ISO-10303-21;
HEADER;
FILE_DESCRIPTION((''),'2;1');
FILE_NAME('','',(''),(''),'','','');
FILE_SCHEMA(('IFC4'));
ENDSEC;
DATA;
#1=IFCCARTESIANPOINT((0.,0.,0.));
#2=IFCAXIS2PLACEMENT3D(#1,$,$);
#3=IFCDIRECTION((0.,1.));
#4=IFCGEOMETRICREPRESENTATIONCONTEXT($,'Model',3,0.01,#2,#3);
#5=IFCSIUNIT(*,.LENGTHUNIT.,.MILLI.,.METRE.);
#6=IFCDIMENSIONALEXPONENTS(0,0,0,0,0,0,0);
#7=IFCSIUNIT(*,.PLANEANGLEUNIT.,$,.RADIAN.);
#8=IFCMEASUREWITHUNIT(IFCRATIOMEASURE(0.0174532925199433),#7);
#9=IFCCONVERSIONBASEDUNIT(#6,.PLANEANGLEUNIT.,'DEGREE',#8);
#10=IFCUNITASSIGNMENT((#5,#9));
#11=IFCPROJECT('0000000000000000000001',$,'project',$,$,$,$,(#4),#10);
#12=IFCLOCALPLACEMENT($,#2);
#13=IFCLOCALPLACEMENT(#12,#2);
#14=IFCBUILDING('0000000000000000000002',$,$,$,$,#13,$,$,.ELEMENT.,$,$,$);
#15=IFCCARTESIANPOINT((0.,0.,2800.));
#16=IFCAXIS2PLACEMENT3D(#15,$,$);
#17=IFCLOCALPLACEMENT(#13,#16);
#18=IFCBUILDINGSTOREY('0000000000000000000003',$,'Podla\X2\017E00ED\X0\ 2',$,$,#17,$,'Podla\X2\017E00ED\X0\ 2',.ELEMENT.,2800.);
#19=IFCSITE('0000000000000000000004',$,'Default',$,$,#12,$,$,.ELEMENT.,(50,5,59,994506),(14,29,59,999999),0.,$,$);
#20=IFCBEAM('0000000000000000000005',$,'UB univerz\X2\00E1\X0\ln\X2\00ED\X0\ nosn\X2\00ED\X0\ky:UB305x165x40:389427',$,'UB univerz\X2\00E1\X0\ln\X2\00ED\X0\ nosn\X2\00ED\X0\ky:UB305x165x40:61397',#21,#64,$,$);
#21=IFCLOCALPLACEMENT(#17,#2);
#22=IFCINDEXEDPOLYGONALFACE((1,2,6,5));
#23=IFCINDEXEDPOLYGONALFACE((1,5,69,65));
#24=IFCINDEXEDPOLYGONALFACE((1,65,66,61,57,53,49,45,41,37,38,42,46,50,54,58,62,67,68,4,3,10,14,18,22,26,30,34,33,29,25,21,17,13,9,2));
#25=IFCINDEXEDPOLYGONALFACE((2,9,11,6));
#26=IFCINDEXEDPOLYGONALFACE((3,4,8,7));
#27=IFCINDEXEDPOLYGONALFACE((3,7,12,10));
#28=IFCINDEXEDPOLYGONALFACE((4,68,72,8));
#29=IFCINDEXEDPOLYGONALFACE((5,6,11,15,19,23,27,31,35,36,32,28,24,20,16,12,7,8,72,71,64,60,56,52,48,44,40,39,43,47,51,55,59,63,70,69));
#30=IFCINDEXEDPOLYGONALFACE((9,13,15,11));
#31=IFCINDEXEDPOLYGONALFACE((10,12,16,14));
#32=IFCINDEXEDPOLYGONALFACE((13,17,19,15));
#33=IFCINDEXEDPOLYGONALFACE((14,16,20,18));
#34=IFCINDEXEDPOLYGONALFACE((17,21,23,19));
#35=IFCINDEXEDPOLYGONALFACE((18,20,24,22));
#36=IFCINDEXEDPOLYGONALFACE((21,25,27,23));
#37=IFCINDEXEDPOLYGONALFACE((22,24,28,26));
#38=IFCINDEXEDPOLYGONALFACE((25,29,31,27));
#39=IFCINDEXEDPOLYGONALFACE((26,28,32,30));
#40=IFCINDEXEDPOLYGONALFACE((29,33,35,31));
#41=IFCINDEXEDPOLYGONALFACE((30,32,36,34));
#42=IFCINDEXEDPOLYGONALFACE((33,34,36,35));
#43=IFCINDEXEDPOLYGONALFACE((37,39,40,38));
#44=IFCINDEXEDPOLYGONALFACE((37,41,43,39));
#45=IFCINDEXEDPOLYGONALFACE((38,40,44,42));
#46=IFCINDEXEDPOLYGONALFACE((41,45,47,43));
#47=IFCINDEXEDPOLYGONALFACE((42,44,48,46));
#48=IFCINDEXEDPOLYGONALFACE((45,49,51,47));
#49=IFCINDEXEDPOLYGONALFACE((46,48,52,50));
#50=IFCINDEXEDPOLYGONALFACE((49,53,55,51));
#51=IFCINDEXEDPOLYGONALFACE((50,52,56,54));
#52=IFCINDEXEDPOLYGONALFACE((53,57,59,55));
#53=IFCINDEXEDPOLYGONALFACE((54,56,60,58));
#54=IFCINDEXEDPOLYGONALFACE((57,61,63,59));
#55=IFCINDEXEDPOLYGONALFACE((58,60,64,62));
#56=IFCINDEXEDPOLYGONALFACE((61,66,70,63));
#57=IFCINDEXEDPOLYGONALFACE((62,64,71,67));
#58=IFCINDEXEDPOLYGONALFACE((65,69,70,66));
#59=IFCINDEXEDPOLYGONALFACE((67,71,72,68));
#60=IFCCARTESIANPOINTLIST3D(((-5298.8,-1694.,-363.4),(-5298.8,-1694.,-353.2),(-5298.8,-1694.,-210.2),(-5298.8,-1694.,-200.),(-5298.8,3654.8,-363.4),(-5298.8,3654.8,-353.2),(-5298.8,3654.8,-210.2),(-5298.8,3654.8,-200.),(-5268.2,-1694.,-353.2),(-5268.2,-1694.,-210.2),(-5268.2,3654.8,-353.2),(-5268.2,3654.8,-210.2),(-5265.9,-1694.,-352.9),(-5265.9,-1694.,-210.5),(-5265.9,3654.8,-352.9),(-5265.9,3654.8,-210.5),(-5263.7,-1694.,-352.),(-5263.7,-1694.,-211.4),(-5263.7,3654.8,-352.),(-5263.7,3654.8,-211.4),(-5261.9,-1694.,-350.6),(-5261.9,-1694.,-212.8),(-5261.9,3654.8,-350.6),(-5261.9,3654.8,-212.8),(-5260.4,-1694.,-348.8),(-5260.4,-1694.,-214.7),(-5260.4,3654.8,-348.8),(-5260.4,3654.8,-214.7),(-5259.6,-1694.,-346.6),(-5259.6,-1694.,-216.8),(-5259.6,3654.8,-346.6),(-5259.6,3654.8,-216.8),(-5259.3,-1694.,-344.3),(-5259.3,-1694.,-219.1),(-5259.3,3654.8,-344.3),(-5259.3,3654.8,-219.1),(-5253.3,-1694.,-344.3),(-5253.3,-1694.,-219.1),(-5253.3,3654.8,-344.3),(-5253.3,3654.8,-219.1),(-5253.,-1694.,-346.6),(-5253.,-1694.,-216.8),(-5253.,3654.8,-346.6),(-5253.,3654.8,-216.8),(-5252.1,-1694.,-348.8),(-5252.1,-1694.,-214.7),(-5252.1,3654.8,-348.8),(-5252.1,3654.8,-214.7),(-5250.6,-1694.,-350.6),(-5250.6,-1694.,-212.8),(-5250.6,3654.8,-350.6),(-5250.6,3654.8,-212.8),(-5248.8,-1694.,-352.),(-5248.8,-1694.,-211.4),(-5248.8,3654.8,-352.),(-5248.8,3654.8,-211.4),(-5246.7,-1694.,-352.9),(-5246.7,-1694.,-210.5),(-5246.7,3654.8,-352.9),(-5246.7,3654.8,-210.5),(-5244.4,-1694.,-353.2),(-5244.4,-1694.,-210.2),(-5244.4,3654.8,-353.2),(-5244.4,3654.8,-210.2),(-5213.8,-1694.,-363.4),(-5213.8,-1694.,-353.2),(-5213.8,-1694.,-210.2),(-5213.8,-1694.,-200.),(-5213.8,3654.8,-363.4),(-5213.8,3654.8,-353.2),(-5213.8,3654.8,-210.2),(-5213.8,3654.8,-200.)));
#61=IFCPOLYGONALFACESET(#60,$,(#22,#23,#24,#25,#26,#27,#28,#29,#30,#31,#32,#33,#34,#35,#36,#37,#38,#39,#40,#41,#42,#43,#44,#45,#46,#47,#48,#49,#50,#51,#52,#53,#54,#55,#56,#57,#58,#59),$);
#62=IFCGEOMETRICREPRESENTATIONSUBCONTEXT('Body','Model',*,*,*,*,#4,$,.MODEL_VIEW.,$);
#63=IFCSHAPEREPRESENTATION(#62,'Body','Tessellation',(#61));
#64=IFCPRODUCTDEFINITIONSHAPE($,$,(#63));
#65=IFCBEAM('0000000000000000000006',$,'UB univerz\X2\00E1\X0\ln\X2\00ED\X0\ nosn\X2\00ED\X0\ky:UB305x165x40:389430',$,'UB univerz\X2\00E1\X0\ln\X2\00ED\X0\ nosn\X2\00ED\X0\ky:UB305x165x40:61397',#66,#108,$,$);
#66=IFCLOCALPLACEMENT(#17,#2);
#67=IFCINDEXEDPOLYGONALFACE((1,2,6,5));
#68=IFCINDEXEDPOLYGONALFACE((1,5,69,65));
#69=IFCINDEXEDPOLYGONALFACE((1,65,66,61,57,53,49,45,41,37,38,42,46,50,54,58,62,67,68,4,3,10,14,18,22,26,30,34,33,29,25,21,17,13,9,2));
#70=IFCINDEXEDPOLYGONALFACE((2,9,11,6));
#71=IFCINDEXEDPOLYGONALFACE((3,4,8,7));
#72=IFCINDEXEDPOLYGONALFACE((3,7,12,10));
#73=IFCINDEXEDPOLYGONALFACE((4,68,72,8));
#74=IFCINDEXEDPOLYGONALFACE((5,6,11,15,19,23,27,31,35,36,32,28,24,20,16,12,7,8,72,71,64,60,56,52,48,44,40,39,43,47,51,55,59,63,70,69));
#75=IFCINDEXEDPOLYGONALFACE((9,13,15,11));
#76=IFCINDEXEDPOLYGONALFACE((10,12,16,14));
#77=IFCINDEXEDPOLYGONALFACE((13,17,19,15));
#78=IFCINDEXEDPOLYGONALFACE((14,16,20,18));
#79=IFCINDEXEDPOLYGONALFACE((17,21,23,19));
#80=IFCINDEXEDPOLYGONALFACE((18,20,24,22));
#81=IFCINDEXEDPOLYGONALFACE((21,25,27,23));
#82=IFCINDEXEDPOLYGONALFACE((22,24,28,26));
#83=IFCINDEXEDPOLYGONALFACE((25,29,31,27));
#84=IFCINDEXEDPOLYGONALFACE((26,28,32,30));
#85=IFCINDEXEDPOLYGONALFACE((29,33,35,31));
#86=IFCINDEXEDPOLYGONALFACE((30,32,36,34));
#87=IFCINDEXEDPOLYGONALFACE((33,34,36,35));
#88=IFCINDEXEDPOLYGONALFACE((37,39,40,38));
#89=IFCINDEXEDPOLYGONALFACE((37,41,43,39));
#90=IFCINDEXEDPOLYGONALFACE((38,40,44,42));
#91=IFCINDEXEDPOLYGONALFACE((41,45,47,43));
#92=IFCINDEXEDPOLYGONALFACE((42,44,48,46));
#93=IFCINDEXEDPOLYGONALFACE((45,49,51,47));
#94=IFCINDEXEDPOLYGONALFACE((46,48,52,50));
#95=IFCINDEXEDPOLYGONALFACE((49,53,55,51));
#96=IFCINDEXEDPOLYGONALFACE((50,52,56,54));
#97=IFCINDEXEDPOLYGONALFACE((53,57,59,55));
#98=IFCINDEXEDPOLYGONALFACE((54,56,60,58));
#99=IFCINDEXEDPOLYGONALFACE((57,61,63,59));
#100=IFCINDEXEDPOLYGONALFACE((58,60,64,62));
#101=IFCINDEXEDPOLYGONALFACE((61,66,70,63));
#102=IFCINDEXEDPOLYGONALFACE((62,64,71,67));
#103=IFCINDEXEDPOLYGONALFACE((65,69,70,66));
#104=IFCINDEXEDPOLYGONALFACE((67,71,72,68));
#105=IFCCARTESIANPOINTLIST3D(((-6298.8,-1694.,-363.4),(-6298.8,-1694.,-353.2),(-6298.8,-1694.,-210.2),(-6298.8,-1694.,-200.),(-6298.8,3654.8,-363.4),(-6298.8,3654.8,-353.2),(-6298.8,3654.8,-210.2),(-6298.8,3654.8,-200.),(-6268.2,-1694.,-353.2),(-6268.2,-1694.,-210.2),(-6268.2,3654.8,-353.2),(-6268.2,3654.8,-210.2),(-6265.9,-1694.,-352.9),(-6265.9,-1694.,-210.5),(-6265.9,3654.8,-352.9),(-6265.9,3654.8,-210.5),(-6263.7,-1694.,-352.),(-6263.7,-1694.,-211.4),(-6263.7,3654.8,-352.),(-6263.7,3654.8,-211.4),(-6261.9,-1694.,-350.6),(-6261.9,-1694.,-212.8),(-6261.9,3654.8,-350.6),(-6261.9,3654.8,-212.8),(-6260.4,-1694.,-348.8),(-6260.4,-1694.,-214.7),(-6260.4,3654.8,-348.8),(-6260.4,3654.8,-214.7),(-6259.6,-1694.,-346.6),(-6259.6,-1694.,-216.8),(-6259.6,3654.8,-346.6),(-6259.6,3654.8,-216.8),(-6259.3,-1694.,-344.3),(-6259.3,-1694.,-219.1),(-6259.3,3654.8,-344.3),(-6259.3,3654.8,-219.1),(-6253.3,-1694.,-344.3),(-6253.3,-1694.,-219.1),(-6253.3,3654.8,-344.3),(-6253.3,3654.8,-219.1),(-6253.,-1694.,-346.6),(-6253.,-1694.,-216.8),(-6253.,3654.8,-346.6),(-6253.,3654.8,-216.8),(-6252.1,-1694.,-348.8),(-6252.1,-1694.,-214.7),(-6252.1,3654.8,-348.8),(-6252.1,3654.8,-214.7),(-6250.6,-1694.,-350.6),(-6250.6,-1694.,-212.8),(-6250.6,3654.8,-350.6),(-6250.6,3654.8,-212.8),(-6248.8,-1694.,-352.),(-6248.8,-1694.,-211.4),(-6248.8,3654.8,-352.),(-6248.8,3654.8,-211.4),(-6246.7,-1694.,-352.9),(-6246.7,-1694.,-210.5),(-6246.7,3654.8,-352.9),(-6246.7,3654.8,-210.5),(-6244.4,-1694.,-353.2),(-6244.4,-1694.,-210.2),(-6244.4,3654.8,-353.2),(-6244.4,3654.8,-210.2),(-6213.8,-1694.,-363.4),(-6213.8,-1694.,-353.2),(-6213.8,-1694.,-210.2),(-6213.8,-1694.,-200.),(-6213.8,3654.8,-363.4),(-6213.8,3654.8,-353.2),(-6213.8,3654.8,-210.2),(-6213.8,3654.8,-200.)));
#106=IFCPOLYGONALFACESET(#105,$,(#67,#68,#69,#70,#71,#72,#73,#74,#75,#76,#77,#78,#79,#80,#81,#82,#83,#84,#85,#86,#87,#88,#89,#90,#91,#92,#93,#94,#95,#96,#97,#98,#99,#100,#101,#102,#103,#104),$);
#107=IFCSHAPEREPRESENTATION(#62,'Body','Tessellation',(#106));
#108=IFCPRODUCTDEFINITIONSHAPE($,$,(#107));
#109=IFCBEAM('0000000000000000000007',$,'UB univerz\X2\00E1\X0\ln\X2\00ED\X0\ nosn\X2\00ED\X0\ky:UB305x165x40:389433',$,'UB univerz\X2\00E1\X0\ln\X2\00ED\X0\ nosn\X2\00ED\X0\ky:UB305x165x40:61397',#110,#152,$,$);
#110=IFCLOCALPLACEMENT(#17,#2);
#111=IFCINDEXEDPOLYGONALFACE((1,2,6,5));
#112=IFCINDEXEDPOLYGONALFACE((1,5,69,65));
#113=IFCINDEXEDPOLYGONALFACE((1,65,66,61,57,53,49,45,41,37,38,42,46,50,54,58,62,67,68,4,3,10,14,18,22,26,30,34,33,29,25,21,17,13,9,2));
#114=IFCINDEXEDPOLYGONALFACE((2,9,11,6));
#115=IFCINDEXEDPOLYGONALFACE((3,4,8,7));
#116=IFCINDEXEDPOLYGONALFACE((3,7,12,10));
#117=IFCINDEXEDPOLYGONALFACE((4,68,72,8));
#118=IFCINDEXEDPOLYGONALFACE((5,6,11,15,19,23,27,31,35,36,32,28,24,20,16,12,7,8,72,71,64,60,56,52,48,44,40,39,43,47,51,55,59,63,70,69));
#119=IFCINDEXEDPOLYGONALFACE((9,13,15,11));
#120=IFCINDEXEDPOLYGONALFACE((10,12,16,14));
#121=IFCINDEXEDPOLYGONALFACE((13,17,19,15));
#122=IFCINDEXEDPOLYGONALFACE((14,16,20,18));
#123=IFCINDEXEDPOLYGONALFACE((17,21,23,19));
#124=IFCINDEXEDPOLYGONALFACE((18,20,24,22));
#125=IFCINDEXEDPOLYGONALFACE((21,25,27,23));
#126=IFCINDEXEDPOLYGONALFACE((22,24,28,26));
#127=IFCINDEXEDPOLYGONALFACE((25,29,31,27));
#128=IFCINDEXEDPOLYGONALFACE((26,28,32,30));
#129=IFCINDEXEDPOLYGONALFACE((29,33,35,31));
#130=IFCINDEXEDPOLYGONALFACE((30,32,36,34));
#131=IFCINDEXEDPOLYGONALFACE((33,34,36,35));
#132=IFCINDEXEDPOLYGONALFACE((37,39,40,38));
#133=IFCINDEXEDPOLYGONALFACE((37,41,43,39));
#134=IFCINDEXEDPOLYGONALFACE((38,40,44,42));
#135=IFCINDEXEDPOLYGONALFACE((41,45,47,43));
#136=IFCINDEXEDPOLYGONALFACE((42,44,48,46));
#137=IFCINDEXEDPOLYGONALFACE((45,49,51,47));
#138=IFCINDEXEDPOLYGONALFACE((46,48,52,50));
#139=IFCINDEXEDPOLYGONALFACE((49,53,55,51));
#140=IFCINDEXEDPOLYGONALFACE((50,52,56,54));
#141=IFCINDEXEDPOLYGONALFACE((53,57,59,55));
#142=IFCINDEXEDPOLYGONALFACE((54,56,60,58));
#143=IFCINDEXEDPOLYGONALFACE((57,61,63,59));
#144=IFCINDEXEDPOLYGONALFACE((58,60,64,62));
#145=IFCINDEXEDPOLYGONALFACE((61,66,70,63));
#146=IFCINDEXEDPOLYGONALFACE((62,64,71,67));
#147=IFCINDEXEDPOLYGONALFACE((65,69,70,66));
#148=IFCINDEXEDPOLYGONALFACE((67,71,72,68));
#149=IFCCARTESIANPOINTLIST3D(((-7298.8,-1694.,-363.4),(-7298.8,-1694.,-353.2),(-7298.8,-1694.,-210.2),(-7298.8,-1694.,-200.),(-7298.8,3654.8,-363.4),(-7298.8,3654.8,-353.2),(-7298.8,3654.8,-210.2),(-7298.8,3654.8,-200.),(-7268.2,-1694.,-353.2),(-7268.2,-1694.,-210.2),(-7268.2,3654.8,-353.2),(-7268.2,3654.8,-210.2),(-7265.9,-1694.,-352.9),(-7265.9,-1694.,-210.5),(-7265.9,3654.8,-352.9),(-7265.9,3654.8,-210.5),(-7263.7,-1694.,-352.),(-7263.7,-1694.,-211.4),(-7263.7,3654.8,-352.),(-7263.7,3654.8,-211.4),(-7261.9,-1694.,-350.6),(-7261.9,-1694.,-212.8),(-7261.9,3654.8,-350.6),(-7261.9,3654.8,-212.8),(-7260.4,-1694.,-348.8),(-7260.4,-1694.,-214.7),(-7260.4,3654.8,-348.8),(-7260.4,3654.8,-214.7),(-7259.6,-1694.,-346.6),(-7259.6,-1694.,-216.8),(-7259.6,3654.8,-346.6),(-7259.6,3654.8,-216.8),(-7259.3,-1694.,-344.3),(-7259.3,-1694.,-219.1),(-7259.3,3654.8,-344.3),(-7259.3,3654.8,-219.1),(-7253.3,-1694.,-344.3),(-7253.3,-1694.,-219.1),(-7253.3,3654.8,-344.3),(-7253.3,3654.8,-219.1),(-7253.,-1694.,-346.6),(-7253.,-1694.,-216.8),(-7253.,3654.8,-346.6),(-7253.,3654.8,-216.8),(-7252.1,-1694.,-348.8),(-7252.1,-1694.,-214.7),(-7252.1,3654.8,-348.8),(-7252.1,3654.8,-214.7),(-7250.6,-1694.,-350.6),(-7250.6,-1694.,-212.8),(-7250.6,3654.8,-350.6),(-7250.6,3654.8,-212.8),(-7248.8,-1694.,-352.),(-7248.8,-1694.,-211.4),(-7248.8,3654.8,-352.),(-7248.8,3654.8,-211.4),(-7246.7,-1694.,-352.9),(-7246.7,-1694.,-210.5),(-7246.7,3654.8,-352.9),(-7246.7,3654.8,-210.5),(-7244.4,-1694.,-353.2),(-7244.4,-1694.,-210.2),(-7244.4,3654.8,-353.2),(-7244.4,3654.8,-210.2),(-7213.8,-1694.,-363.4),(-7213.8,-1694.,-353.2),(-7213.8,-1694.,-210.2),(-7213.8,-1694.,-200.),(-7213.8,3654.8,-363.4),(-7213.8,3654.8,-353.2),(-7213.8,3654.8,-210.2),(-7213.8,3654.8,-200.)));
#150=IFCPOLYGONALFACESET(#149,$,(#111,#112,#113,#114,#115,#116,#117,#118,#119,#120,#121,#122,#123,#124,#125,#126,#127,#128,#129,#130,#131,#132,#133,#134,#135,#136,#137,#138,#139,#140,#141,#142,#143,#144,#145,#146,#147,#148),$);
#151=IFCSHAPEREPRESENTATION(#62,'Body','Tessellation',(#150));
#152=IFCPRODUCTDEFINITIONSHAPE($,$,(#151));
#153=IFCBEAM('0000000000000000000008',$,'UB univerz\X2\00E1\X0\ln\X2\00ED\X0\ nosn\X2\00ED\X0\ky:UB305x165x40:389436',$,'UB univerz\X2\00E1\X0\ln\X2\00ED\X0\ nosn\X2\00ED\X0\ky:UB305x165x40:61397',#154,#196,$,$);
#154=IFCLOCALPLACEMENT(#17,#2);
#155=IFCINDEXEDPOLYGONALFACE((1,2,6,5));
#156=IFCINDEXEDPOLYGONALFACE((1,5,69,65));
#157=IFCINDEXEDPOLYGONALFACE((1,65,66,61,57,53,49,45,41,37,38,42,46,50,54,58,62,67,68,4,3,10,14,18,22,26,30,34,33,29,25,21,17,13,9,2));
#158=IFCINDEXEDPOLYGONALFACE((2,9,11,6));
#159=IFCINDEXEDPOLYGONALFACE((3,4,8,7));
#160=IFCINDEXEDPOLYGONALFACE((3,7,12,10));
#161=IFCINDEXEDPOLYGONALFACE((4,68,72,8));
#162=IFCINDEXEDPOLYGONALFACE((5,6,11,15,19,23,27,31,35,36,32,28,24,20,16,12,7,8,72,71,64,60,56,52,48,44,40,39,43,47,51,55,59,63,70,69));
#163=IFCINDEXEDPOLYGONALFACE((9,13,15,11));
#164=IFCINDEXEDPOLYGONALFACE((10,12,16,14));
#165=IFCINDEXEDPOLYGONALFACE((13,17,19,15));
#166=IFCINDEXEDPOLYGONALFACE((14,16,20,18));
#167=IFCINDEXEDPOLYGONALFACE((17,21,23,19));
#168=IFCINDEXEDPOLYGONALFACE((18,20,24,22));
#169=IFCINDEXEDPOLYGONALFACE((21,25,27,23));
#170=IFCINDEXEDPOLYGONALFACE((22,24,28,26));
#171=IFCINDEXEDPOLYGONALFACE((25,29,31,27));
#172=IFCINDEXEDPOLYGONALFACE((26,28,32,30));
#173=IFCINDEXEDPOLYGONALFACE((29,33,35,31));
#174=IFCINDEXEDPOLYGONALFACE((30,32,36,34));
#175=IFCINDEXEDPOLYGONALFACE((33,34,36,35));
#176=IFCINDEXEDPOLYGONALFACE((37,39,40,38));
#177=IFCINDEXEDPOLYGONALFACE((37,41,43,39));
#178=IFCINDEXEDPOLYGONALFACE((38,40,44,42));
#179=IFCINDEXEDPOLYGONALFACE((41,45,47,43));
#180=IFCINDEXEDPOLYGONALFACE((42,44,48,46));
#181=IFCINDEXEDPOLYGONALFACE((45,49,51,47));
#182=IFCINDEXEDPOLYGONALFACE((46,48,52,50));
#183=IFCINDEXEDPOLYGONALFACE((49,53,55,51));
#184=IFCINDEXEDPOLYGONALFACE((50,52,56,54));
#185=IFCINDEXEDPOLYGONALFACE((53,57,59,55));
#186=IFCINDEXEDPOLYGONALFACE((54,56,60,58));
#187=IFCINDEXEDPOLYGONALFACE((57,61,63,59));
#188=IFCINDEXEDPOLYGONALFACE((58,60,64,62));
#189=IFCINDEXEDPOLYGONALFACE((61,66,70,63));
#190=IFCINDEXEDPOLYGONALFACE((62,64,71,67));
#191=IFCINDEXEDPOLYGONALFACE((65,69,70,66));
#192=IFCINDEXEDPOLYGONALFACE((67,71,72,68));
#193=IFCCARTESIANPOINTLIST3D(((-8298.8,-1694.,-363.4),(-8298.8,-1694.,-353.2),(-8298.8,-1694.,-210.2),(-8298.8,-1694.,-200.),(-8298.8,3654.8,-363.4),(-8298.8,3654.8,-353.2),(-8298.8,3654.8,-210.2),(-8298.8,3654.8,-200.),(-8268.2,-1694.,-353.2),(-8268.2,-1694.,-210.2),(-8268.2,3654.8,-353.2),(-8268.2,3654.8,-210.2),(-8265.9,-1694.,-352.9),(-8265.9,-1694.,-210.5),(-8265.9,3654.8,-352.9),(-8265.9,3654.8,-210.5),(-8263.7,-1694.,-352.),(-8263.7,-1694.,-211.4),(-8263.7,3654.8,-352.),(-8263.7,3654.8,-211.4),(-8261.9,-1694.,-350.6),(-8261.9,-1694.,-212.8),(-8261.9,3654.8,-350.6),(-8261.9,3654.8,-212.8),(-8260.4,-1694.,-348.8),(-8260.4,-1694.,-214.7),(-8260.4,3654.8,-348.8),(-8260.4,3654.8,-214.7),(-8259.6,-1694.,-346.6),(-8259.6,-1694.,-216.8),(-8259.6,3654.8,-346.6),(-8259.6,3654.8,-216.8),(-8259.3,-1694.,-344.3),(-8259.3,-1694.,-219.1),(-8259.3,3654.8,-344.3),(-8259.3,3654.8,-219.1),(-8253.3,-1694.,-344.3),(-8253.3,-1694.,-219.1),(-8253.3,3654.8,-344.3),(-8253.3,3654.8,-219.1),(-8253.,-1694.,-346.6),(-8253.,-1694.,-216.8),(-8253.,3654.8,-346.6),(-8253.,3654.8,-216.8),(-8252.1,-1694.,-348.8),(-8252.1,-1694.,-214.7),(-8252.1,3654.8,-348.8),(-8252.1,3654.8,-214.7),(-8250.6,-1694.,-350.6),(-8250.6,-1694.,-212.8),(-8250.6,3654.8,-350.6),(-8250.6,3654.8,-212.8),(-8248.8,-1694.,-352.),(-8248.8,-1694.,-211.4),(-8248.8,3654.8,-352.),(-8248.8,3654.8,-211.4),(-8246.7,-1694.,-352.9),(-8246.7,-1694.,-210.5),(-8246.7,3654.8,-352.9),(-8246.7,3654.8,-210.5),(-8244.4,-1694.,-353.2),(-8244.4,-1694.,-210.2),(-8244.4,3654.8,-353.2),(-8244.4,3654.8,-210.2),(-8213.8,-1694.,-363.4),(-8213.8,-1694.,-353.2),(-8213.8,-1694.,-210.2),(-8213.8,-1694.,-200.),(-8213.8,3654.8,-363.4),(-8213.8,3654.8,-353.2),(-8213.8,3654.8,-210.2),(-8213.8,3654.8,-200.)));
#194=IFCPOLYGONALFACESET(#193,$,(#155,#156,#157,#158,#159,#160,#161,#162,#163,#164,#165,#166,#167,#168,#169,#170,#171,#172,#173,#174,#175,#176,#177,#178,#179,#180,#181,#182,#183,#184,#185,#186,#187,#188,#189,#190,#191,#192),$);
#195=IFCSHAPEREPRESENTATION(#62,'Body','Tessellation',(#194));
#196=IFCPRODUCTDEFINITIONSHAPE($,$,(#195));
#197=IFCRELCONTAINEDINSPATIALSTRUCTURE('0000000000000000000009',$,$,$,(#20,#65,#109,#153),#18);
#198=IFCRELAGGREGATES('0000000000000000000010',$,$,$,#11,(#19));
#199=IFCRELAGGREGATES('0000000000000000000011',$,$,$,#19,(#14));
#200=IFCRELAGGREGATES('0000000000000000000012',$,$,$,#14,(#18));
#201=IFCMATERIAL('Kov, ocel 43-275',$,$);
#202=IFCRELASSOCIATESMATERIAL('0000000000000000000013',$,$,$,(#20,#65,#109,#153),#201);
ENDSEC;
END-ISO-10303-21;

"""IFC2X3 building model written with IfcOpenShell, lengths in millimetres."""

from ifc_helpers import new_model, entity, si_unit, converted_unit, direction, frame, frame_2d, origin, place, context, subcontext, project, spatial, i_section, extrude, material, element, save


model = new_model("IFC2X3")

# Units and contexts
model_context = context("Model", 3, precision=0.01, world=origin(), true_north=direction((0.0, 1.0)))
body_context = subcontext(model_context, "Body", "Model", "MODEL_VIEW")
ifc_project = project(units=[si_unit("LENGTHUNIT", "METRE", prefix="MILLI"), converted_unit("PLANEANGLEUNIT", "DEGREE", entity("IfcRatioMeasure", 0.0174532925199433), si_unit("PLANEANGLEUNIT", "RADIAN"), dimensions=[0, 0, 0, 0, 0, 0, 0])], contexts=[model_context])

# Site, building, storey
site_placement = place(None, origin())
site = spatial("IfcSite", under=ifc_project, at=site_placement, Name="Default", CompositionType="ELEMENT", RefLatitude=(50, 5, 59, 994506), RefLongitude=(14, 29, 59, 999999), RefElevation=0.0)
building_placement = place(site_placement, origin())
building = spatial("IfcBuilding", under=site, at=building_placement, CompositionType="ELEMENT")
storey_placement = place(building_placement, frame((0.0, 0.0, 2800.0)))
storey = spatial("IfcBuildingStorey", under=building, at=storey_placement, Name="Podlaží 2", LongName="Podlaží 2", CompositionType="ELEMENT", Elevation=2800.0)

# Beams
ifc_material = material(Name="Kov, ocel 43-275")
beam_1_placement = place(storey_placement, frame((-5256.3, 3654.8, 0.0), z_axis=(0.0, 0.0, 1.0), x_axis=(0.0, -1.0, 0.0)))
element("IfcBeam", 1, at=beam_1_placement, inside=storey, material=ifc_material, Name="UB univerzální nosníky:UB305x165x40:389427", ObjectType="UB univerzální nosníky:UB305x165x40:61397", context=body_context, shape_type="SweptSolid", body=[
    extrude(i_section(OverallWidth=85.0, OverallDepth=163.4, WebThickness=6.0, FlangeThickness=10.2, FilletRadius=8.9, at=frame_2d((0.0, 0.0), x_axis=(0.0, 1.0))), frame((0.0, 0.0, -281.7), z_axis=(1.0, 0.0, 0.0), x_axis=(0.0, 0.0, -1.0)), (0.0, 0.0, 1.0), 5348.8),
])
beam_2_placement = place(storey_placement, frame((-6256.3, 3654.8, 0.0), z_axis=(0.0, 0.0, 1.0), x_axis=(0.0, -1.0, 0.0)))
element("IfcBeam", 2, at=beam_2_placement, inside=storey, material=ifc_material, Name="UB univerzální nosníky:UB305x165x40:389430", ObjectType="UB univerzální nosníky:UB305x165x40:61397", context=body_context, shape_type="SweptSolid", body=[
    extrude(i_section(OverallWidth=85.0, OverallDepth=163.4, WebThickness=6.0, FlangeThickness=10.2, FilletRadius=8.9, at=frame_2d((0.0, 0.0), x_axis=(0.0, 1.0))), frame((0.0, 0.0, -281.7), z_axis=(1.0, 0.0, 0.0), x_axis=(0.0, 0.0, -1.0)), (0.0, 0.0, 1.0), 5348.8),
])
beam_3_placement = place(storey_placement, frame((-7256.3, 3654.8, 0.0), z_axis=(0.0, 0.0, 1.0), x_axis=(0.0, -1.0, 0.0)))
element("IfcBeam", 3, at=beam_3_placement, inside=storey, material=ifc_material, Name="UB univerzální nosníky:UB305x165x40:389433", ObjectType="UB univerzální nosníky:UB305x165x40:61397", context=body_context, shape_type="SweptSolid", body=[
    extrude(i_section(OverallWidth=85.0, OverallDepth=163.4, WebThickness=6.0, FlangeThickness=10.2, FilletRadius=8.9, at=frame_2d((0.0, 0.0), x_axis=(0.0, 1.0))), frame((0.0, 0.0, -281.7), z_axis=(1.0, 0.0, 0.0), x_axis=(0.0, 0.0, -1.0)), (0.0, 0.0, 1.0), 5348.8),
])
for number, where, z_axis, x_axis, name in (
    (4, (-8256.3, 3654.8, 0.0), (0.0, 0.0, 1.0), (0.0, -1.0, 0.0), "UB univerzální nosníky:UB305x165x40:389436"),
):
    element("IfcBeam", number, at=place(storey_placement, frame(where, z_axis=z_axis, x_axis=x_axis)), inside=storey, material=ifc_material, Name=name, ObjectType="UB univerzální nosníky:UB305x165x40:61397", context=body_context, shape_type="SweptSolid", body=[
        extrude(i_section(OverallWidth=85.0, OverallDepth=163.4, WebThickness=6.0, FlangeThickness=10.2, FilletRadius=8.9, at=frame_2d((0.0, 0.0), x_axis=(0.0, 1.0))), frame((0.0, 0.0, -281.7), z_axis=(1.0, 0.0, 0.0), x_axis=(0.0, 0.0, -1.0)), (0.0, 0.0, 1.0), 5348.8),
    ])

save(model, "model.ifc")
